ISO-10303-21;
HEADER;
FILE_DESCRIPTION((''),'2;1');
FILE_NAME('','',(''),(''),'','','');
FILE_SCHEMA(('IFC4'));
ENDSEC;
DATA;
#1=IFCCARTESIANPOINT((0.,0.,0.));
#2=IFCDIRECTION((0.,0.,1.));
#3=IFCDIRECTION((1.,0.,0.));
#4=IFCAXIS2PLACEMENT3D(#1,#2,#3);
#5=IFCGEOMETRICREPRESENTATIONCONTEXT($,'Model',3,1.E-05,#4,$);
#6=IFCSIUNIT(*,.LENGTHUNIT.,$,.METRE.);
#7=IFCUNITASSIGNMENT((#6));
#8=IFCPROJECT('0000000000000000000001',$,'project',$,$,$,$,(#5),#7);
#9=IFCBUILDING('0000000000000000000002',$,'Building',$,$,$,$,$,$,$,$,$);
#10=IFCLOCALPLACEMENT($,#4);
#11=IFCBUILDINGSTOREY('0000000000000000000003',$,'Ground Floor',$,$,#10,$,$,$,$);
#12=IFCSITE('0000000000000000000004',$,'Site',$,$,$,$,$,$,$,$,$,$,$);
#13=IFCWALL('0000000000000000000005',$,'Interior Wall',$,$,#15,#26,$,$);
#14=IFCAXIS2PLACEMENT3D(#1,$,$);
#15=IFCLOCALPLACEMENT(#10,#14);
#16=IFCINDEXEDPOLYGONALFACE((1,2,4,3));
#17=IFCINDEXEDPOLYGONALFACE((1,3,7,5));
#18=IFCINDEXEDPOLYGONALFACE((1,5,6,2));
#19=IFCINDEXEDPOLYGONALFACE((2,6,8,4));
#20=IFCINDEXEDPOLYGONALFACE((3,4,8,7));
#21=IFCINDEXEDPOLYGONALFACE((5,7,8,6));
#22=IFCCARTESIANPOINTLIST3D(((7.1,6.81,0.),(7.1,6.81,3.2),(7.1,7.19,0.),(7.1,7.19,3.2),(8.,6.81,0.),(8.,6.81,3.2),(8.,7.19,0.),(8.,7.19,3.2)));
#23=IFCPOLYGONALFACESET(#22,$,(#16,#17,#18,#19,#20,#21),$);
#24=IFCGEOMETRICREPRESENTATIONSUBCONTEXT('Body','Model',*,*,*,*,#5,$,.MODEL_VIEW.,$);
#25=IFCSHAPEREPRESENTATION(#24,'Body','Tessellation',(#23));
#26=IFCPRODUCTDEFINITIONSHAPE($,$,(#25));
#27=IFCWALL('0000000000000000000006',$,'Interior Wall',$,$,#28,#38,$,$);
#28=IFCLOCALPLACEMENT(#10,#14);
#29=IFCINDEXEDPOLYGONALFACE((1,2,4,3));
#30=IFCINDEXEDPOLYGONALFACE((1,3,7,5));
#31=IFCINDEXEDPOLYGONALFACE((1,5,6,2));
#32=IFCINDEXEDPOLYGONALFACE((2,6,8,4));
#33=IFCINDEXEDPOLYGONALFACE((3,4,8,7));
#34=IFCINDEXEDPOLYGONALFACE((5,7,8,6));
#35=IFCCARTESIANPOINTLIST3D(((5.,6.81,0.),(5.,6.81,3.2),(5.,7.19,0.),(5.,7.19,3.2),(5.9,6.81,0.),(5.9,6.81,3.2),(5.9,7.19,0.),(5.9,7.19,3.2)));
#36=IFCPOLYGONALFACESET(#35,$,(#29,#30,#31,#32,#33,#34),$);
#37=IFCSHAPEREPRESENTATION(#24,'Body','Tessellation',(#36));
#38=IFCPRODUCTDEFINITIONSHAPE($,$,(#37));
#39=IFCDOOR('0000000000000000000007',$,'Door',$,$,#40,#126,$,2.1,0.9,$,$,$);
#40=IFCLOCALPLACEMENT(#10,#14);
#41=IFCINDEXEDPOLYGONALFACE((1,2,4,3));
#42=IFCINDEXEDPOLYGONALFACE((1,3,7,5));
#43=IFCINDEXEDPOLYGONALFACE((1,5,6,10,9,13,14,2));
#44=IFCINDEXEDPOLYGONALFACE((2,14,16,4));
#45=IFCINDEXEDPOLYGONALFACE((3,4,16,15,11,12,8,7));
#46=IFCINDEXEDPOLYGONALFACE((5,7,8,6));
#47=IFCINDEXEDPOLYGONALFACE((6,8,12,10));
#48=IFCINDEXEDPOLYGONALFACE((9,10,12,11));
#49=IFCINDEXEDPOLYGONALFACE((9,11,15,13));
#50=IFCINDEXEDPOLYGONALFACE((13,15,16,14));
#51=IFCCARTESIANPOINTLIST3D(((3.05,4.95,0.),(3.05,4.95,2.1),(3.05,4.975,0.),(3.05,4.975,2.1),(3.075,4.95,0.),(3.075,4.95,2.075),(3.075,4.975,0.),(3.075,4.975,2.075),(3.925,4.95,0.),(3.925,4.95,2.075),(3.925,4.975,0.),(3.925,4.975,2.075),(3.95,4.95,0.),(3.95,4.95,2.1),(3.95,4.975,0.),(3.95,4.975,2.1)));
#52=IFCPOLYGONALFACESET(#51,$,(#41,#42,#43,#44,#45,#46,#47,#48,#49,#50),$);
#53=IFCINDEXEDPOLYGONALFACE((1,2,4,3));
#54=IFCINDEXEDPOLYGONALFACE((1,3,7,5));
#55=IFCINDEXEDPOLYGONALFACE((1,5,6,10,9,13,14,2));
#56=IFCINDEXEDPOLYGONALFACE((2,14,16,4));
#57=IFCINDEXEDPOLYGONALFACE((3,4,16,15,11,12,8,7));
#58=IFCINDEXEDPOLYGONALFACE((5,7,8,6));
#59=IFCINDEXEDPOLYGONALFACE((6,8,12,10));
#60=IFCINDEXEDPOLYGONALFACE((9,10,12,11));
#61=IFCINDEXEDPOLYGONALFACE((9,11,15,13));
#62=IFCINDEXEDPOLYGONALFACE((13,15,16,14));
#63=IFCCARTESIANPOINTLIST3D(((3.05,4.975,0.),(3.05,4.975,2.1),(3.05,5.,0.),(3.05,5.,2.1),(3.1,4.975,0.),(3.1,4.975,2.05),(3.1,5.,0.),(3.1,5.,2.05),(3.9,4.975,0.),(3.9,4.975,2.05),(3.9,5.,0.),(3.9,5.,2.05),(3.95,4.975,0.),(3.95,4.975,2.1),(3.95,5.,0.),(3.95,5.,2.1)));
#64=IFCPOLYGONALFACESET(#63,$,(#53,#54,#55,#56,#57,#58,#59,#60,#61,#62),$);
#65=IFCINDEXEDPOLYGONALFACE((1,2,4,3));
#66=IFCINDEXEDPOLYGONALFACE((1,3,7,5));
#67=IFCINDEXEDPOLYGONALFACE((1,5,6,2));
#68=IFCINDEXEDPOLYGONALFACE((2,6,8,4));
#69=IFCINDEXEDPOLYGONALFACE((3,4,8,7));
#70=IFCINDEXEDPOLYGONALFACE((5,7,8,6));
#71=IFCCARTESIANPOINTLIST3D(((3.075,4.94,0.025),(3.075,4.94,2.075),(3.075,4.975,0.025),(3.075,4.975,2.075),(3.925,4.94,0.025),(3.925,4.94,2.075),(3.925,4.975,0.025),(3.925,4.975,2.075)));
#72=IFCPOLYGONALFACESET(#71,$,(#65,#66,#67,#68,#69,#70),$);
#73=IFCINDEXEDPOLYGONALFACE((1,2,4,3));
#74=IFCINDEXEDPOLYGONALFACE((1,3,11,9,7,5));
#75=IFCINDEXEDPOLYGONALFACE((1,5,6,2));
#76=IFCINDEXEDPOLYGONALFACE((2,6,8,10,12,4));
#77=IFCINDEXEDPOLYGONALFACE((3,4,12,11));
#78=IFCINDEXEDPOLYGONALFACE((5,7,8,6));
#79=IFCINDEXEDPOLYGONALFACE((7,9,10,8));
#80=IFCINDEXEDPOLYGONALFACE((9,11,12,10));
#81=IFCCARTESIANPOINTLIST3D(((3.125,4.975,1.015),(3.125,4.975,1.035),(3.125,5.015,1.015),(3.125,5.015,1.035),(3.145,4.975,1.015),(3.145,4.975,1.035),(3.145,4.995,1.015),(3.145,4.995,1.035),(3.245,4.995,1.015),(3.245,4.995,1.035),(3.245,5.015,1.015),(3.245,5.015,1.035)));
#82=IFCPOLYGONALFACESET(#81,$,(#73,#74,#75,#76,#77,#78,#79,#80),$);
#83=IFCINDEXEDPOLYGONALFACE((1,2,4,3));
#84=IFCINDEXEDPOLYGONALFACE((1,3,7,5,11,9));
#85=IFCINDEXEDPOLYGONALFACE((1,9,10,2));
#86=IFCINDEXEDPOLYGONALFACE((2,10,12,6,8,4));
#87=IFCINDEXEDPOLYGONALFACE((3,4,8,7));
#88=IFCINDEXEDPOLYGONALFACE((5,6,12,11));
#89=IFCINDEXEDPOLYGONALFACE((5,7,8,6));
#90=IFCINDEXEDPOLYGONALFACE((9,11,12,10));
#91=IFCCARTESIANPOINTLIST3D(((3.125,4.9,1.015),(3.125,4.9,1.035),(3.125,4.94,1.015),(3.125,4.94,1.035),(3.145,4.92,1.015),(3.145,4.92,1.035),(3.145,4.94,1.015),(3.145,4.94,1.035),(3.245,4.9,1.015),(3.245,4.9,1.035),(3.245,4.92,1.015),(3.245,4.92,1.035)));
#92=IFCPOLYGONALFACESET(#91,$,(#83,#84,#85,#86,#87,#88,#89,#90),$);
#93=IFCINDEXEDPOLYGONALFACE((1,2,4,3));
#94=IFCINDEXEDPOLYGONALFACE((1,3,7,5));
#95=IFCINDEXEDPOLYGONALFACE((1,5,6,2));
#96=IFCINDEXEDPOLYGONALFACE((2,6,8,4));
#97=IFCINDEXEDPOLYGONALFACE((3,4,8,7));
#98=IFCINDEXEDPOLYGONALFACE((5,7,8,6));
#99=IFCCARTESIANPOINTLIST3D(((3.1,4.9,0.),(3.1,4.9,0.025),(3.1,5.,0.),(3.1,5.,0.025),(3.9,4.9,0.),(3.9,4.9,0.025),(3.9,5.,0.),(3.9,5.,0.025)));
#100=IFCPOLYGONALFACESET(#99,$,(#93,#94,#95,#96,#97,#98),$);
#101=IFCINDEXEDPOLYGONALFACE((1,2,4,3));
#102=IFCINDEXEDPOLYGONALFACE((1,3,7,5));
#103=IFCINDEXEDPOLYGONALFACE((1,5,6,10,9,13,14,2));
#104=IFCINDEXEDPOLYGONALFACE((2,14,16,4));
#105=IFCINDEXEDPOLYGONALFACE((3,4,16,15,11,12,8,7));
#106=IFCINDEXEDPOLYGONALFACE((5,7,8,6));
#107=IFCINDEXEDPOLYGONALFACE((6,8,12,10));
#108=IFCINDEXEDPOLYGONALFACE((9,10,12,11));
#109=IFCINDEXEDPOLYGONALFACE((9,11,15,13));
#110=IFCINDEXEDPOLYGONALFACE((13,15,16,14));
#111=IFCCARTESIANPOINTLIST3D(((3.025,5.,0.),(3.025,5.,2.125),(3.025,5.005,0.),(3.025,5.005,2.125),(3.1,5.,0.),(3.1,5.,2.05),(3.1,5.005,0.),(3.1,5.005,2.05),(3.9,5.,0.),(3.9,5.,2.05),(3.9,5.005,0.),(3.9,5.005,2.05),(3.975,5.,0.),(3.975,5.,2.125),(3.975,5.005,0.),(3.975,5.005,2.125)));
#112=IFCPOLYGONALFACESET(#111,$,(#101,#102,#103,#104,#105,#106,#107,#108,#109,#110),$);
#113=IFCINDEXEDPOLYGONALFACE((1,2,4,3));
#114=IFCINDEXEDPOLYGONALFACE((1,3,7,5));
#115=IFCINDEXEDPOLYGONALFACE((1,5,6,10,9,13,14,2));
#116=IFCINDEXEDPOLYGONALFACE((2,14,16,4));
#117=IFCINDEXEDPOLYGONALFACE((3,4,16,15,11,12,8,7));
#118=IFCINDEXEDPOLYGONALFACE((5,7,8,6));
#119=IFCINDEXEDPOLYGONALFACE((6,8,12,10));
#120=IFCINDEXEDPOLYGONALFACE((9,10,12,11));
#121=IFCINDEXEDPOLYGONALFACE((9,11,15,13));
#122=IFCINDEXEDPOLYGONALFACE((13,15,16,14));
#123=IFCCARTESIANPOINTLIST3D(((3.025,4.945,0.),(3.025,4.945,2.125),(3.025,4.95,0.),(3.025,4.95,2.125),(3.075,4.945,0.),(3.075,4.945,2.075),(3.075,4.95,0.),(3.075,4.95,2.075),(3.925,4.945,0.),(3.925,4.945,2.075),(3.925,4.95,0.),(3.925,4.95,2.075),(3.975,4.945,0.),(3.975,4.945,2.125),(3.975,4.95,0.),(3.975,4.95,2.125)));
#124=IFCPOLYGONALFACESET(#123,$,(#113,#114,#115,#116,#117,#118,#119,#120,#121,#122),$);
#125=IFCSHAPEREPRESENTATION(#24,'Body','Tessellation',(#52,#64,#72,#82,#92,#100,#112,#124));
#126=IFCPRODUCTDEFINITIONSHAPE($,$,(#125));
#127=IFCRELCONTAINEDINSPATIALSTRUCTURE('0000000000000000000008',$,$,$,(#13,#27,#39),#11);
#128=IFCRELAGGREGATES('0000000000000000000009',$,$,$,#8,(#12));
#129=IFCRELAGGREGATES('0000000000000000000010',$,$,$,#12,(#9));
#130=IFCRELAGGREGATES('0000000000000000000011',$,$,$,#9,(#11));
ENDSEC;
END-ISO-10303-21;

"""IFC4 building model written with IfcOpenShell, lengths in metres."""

from ifc_helpers import new_model, si_unit, frame, origin_with_axes, place, context, subcontext, project, spatial, line, indexed_curve, outline, extrude, element, save


model = new_model("IFC4")

# Units and contexts
model_context = context("Model", 3, precision=1e-05, world=origin_with_axes())
body_context = subcontext(model_context, "Body", "Model", "MODEL_VIEW")
ifc_project = project(units=[si_unit("LENGTHUNIT", "METRE")], contexts=[model_context])

# Site, building, storey
site = spatial("IfcSite", under=ifc_project, Name="Site")
building = spatial("IfcBuilding", under=site, Name="Building")
storey_placement = place(None, origin_with_axes())
storey = spatial("IfcBuildingStorey", under=building, at=storey_placement, Name="Ground Floor")

# Walls
for number, where, z_axis, x_axis, name in (
    (1, (8.0, 7.0, 0.0), (0.0, 0.0, 1.0), (-1.0, 0.0, 0.0), "Interior Wall"),
    (2, (5.9, 7.0, 0.0), (0.0, 0.0, 1.0), (-1.0, 0.0, 0.0), "Interior Wall"),
):
    element("IfcWall", number, at=place(storey_placement, frame(where, z_axis=z_axis, x_axis=x_axis)), inside=storey, Name=name, context=body_context, shape_type="SweptSolid", body=[
        extrude(outline(indexed_curve([(0.0, 0.0), (0.0, 0.38), (0.9, 0.38), (0.9, 0.0), (0.0, 0.0)], self_intersect=False)), frame((0.0, -0.19, 0.0), z_axis=(0.0, 0.0, 1.0), x_axis=(1.0, 0.0, 0.0)), (0.0, 0.0, 1.0), 3.2),
    ])

# Door
door_1_placement = place(storey_placement, frame((3.95, 5.0, 0.0), z_axis=(0.0, 0.0, 1.0), x_axis=(-1.0, 0.0, 0.0)))
element("IfcDoor", 3, at=door_1_placement, inside=storey, Name="Door", OverallHeight=2.1, OverallWidth=0.9, context=body_context, shape_type="SweptSolid", body=[
    extrude(outline(indexed_curve([(0.0, 0.0), (0.0, 2.1), (0.9, 2.1), (0.9, 0.0), (0.875, 0.0), (0.875, 2.075), (0.025, 2.075), (0.025, 0.0)], segments=[line(1, 2, 3, 4, 5, 6, 7, 8, 1)])), frame((0.0, 0.025, 0.0), z_axis=(0.0, -1.0, 0.0), x_axis=(1.0, 0.0, 0.0)), (0.0, 0.0, -1.0), 0.025),
    extrude(outline(indexed_curve([(0.0, 0.0), (0.0, 2.1), (0.9, 2.1), (0.9, 0.0), (0.85, 0.0), (0.85, 2.05), (0.05, 2.05), (0.05, 0.0)], segments=[line(1, 2, 3, 4, 5, 6, 7, 8, 1)])), frame((0.0, 0.0, 0.0), z_axis=(0.0, -1.0, 0.0), x_axis=(1.0, 0.0, 0.0)), (0.0, 0.0, -1.0), 0.025),
    extrude(outline(indexed_curve([(0.0, 0.0), (0.85, 0.0), (0.85, 0.035), (0.0, 0.035)], segments=[line(1, 2, 3, 4, 1)])), frame((0.025, 0.025, 0.025), z_axis=(0.0, 0.0, 1.0), x_axis=(1.0, 0.0, 0.0)), (0.0, 0.0, 1.0), 2.05),
    extrude(outline(indexed_curve([(0.0, 0.0), (0.0, -0.04), (-0.12, -0.04), (-0.12, -0.02), (-0.02, -0.02), (-0.02, 0.0)], segments=[line(1, 2, 3, 4, 5, 6, 1)])), frame((0.825, 0.025, 1.015), z_axis=(0.0, 0.0, 1.0), x_axis=(1.0, 0.0, 0.0)), (0.0, 0.0, 1.0), 0.02),
    extrude(outline(indexed_curve([(0.0, 0.0), (0.0, 0.04), (-0.12, 0.04), (-0.12, 0.02), (-0.02, 0.02), (-0.02, 0.0)], segments=[line(1, 2, 3, 4, 5, 6, 1)])), frame((0.825, 0.06, 1.015), z_axis=(0.0, 0.0, 1.0), x_axis=(1.0, 0.0, 0.0)), (0.0, 0.0, 1.0), 0.02),
    extrude(outline(indexed_curve([(0.0, 0.0), (0.8, 0.0), (0.8, 0.1), (0.0, 0.1)], segments=[line(1, 2, 3, 4, 1)])), frame((0.05, 0.0, 0.0), z_axis=(0.0, 0.0, 1.0), x_axis=(1.0, 0.0, 0.0)), (0.0, 0.0, 1.0), 0.025),
    extrude(outline(indexed_curve([(0.0, 0.0), (0.0, 2.125), (0.95, 2.125), (0.95, 0.0), (0.875, 0.0), (0.875, 2.05), (0.075, 2.05), (0.075, 0.0)], segments=[line(1, 2, 3, 4, 5, 6, 7, 8, 1)])), frame((-0.025, -0.005, 0.0), z_axis=(0.0, -1.0, 0.0), x_axis=(1.0, 0.0, 0.0)), (0.0, 0.0, -1.0), 0.005),
    extrude(outline(indexed_curve([(0.0, 0.0), (0.0, 2.125), (0.95, 2.125), (0.95, 0.0), (0.9, 0.0), (0.9, 2.075), (0.05, 2.075), (0.05, 0.0)], segments=[line(1, 2, 3, 4, 5, 6, 7, 8, 1)])), frame((-0.025, 0.05, 0.0), z_axis=(0.0, -1.0, 0.0), x_axis=(1.0, 0.0, 0.0)), (0.0, 0.0, -1.0), 0.005),
])

save(model, "model.ifc")
